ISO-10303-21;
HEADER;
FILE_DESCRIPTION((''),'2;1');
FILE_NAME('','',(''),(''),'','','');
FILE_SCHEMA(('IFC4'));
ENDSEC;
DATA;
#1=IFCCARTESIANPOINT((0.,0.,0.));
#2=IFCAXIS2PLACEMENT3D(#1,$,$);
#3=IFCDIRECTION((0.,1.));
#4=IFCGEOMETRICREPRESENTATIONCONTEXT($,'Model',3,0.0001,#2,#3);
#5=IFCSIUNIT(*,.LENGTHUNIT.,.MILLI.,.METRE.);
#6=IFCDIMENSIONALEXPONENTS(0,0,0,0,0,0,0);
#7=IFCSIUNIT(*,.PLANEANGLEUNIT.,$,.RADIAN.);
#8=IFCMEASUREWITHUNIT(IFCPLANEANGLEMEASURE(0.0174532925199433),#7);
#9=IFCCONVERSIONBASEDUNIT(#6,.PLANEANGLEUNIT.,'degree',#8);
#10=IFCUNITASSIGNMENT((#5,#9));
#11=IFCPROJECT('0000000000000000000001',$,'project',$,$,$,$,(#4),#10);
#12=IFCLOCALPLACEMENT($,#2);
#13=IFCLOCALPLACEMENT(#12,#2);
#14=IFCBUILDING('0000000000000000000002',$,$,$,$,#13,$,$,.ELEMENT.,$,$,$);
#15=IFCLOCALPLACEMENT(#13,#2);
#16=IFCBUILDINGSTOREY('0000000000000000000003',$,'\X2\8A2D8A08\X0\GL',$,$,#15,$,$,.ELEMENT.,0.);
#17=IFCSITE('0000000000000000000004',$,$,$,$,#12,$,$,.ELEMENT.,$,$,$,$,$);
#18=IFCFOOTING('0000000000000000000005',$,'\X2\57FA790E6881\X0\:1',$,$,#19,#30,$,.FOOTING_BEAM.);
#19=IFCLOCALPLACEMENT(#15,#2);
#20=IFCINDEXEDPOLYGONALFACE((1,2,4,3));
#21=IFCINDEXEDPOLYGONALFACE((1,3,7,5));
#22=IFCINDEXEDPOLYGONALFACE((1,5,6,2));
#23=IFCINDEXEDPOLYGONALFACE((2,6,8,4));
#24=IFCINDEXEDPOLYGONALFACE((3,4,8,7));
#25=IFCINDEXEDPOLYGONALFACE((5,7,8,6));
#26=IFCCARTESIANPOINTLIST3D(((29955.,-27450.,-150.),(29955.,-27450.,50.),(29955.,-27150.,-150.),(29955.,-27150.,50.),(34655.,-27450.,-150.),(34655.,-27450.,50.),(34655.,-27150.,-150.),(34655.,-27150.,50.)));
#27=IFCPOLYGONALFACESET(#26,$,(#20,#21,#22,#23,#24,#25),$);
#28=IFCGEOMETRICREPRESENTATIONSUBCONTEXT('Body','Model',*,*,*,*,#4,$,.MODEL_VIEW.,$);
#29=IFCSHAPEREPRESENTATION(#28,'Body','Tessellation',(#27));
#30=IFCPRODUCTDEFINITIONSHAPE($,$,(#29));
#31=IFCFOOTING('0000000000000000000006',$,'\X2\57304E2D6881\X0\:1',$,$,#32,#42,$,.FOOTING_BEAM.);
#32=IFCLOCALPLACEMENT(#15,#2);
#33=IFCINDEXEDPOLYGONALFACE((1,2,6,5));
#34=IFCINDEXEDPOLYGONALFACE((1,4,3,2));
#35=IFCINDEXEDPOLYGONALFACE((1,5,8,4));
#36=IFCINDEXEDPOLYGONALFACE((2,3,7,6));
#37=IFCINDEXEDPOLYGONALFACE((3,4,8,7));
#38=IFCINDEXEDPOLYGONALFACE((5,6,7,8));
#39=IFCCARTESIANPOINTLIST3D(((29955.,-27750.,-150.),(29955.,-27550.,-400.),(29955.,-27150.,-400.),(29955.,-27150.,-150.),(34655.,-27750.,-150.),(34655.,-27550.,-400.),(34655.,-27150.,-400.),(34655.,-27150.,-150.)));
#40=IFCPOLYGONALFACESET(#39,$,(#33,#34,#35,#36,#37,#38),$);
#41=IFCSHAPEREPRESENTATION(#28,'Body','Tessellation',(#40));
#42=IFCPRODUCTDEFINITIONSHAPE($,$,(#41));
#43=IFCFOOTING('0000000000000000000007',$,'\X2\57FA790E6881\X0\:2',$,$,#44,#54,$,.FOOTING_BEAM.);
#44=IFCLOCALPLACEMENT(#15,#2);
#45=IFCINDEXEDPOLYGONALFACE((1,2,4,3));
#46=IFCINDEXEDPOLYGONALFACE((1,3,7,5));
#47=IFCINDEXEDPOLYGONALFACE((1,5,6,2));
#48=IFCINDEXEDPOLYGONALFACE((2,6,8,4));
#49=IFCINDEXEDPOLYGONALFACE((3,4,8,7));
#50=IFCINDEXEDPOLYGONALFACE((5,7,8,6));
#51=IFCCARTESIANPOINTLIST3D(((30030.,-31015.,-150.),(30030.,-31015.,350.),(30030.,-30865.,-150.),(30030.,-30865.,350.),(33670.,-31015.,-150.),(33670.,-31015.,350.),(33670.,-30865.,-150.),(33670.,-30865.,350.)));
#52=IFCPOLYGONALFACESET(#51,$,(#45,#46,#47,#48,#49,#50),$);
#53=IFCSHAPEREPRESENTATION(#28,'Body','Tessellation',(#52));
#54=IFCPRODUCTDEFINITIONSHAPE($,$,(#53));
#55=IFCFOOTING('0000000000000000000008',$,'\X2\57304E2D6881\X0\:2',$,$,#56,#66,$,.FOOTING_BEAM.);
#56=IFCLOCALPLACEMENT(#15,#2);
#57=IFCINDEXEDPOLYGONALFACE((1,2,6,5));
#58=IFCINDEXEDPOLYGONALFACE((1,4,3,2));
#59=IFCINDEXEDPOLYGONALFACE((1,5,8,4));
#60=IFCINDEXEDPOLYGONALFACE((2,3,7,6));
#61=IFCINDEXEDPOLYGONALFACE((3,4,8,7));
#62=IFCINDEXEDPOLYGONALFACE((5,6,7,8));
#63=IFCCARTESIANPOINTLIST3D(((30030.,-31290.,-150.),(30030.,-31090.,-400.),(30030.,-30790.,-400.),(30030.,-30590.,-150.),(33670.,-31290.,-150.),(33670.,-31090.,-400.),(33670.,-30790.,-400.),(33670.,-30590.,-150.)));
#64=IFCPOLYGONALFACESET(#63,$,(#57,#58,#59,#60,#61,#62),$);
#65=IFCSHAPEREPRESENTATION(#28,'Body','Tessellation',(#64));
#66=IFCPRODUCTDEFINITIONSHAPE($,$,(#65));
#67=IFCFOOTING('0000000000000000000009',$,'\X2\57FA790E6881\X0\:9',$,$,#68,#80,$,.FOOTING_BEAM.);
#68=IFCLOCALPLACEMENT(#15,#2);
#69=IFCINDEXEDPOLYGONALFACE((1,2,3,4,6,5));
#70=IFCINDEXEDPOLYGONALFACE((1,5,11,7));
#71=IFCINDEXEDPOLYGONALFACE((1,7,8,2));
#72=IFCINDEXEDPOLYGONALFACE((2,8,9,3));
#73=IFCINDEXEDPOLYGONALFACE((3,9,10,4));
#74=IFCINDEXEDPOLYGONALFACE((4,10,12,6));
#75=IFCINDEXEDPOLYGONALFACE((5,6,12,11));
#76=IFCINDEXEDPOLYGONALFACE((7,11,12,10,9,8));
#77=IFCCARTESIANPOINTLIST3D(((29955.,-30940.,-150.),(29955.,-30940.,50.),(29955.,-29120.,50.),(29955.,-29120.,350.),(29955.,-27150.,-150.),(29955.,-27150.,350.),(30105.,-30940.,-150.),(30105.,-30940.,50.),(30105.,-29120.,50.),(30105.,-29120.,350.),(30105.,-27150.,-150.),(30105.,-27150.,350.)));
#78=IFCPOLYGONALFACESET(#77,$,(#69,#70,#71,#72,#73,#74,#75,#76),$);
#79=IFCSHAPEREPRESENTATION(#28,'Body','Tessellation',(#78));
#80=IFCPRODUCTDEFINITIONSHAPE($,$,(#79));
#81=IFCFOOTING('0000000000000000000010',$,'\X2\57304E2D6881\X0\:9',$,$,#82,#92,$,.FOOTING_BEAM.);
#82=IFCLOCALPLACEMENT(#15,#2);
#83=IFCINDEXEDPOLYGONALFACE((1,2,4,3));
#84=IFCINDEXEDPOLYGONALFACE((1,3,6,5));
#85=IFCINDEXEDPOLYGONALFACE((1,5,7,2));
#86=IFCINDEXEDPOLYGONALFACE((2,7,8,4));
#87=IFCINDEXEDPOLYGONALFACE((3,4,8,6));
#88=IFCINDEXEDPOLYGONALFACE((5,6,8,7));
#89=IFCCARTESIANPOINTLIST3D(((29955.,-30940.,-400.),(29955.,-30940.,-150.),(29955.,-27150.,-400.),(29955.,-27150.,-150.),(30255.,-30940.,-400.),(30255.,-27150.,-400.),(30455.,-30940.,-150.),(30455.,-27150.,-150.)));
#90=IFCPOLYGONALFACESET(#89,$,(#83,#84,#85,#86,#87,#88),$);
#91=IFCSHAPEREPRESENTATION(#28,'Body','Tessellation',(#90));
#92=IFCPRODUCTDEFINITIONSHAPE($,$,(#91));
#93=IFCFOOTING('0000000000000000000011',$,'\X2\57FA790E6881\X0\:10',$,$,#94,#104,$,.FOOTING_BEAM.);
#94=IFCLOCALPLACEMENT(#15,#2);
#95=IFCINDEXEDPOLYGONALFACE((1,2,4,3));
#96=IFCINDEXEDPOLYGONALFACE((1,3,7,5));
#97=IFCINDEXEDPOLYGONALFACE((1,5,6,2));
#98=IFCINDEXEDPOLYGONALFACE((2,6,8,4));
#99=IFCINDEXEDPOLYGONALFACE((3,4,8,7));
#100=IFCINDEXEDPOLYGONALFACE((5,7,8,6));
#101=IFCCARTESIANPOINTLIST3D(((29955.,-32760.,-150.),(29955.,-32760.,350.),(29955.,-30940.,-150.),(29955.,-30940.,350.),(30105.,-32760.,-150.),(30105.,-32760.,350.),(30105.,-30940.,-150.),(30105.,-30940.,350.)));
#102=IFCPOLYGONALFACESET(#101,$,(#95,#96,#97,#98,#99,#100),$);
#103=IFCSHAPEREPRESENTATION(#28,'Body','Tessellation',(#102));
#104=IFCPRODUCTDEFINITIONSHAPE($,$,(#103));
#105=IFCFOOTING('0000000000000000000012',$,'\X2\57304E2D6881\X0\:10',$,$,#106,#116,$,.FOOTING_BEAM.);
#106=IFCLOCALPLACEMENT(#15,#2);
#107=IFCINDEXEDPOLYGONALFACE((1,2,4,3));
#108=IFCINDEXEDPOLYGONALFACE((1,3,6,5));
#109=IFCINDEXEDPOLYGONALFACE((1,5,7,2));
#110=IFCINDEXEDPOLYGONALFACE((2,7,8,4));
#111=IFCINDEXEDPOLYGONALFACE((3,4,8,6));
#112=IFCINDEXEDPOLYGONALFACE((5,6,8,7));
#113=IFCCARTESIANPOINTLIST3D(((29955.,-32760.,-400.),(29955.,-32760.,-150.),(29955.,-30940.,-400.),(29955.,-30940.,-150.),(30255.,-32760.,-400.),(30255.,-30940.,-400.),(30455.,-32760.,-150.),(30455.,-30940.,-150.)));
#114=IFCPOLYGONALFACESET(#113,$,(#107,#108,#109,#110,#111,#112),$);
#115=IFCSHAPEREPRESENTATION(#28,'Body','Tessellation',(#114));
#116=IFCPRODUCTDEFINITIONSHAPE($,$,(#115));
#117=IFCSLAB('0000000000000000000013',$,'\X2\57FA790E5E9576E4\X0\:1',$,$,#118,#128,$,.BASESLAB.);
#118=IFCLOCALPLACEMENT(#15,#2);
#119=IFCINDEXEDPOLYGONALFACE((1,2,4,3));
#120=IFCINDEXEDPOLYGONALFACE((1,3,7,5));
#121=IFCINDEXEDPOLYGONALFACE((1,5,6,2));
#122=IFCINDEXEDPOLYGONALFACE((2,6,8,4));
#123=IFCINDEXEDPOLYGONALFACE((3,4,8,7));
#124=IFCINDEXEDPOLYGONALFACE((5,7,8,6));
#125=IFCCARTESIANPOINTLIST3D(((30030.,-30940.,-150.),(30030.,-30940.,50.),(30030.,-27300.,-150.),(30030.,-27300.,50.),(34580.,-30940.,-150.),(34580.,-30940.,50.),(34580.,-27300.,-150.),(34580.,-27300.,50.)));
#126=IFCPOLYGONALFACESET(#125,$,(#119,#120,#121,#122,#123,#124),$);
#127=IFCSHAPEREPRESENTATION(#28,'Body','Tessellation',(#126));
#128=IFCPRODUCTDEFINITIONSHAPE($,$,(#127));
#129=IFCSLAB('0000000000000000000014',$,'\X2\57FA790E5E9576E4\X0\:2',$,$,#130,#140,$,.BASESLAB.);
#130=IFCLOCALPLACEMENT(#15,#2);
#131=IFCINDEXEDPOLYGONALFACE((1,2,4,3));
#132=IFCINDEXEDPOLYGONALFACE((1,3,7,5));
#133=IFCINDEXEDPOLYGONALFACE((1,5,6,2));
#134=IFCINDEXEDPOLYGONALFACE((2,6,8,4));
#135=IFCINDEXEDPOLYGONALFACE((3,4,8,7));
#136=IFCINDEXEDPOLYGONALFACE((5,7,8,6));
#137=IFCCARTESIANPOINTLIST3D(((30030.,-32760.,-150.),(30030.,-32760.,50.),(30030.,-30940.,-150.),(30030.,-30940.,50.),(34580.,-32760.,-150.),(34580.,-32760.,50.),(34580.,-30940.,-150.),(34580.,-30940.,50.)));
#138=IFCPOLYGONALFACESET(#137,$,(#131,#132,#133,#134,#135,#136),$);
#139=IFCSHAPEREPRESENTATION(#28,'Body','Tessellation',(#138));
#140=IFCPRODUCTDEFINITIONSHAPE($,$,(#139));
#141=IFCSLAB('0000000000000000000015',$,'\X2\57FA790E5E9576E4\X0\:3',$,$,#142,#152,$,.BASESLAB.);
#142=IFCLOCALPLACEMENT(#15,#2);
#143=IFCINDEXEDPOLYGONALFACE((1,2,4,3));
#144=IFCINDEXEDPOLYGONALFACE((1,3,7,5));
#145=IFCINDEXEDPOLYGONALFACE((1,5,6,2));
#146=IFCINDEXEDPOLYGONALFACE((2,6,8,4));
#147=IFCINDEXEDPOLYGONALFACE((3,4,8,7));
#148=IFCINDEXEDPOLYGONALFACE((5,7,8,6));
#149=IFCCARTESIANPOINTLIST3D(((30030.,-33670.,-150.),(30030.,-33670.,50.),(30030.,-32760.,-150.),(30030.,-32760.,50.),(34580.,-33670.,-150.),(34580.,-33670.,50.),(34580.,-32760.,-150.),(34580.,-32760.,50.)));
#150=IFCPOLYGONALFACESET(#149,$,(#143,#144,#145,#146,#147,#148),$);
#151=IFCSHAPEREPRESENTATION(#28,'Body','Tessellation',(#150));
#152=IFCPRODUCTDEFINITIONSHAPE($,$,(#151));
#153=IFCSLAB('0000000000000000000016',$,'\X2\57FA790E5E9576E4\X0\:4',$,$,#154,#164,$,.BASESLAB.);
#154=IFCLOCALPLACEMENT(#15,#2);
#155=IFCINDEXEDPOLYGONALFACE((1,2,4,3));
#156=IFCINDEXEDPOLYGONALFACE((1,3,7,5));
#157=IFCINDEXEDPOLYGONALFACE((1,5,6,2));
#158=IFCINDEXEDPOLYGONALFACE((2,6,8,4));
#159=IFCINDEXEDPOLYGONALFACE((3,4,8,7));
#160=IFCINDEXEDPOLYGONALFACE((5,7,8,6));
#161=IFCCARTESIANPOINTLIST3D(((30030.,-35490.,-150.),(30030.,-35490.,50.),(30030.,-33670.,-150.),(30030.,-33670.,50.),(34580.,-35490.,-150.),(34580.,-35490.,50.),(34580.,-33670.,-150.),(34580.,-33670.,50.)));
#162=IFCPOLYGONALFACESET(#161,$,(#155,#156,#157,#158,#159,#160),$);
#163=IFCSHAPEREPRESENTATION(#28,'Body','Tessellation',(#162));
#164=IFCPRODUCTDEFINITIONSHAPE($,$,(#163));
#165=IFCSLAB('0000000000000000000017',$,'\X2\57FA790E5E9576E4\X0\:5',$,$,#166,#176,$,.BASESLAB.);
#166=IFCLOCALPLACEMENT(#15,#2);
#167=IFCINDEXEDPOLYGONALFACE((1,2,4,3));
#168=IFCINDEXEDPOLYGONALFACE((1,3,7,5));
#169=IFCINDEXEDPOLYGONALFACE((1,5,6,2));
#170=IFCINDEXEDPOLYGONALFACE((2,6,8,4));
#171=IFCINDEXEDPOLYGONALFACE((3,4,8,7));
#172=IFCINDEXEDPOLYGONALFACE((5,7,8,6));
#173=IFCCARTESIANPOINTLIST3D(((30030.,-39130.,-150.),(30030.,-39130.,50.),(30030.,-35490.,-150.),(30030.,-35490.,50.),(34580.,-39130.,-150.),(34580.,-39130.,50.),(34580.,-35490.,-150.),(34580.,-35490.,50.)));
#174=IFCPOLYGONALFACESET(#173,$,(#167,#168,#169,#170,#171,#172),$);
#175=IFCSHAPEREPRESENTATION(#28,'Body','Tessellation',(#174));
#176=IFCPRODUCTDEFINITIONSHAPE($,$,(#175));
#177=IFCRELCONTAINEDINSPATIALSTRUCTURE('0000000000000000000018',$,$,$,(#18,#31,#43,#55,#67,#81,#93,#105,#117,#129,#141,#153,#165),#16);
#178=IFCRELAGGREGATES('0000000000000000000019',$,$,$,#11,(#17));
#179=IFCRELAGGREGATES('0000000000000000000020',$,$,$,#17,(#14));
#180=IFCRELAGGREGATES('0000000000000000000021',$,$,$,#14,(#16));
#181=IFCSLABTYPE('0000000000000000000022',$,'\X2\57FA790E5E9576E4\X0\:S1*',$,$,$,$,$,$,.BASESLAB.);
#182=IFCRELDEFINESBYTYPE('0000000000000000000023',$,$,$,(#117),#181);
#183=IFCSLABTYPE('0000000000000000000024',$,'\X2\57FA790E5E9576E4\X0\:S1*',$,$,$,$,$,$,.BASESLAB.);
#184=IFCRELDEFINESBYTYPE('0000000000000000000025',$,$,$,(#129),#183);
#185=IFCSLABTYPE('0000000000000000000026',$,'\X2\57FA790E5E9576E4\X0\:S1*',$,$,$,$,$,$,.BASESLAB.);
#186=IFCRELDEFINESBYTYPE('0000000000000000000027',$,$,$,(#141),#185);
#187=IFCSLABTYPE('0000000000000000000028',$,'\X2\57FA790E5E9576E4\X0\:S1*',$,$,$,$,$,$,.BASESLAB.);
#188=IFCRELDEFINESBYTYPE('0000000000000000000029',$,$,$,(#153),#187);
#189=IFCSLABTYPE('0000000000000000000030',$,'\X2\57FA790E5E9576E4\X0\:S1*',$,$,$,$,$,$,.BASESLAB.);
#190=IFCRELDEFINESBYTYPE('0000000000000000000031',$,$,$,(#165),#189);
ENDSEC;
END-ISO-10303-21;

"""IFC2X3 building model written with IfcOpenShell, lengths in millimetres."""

from ifc_helpers import new_model, entity, si_unit, converted_unit, direction, frame, origin, origin_with_axes, origin_2d, place, context, subcontext, project, spatial, polyline, rectangle, outline, extrude, boolean, type_object, element, save


model = new_model("IFC2X3")

# Units and contexts
model_context = context("Model", 3, precision=0.0001, world=origin(), true_north=direction((0.0, 1.0)))
body_context = subcontext(model_context, "Body", "Model", "MODEL_VIEW")
ifc_project = project(units=[si_unit("LENGTHUNIT", "METRE", prefix="MILLI"), converted_unit("PLANEANGLEUNIT", "degree", entity("IfcPlaneAngleMeasure", 0.0174532925199433), si_unit("PLANEANGLEUNIT", "RADIAN"), dimensions=[0, 0, 0, 0, 0, 0, 0])], contexts=[model_context])

# Site, building, storey
site_placement = place(None, origin())
site = spatial("IfcSite", under=ifc_project, at=site_placement, CompositionType="ELEMENT")
building_placement = place(site_placement, origin())
building = spatial("IfcBuilding", under=site, at=building_placement, CompositionType="ELEMENT")
storey_placement = place(building_placement, origin())
storey = spatial("IfcBuildingStorey", under=building, at=storey_placement, Name="設計GL", CompositionType="ELEMENT", Elevation=0.0)

# Footings
footing_1_placement = place(storey_placement, frame((29955.0, -27300.0, -50.0), z_axis=(1.0, 0.0, 0.0), x_axis=(0.0, 1.0, 0.0)))
element("IfcFooting", 1, at=footing_1_placement, inside=storey, Name="基礎梁:1", PredefinedType="FOOTING_BEAM", context=body_context, shape_type="SolidModel", body=[
    extrude(rectangle(XDim=300.0, YDim=200.0, at=origin_2d()), origin_with_axes(), (0.0, 0.0, 1.0), 4700.0),
])
footing_2_placement = place(storey_placement, frame((29955.0, -27150.0, -400.0), z_axis=(1.0, 0.0, 0.0), x_axis=(0.0, 1.0, 0.0)))
element("IfcFooting", 2, at=footing_2_placement, inside=storey, Name="地中梁:1", PredefinedType="FOOTING_BEAM", context=body_context, shape_type="SweptSolid", body=[
    extrude(outline(polyline([(0.0, 0.0, 0.0), (-400.0, 0.0, 0.0), (-600.0, 250.0, 0.0), (0.0, 250.0, 0.0), (0.0, 0.0, 0.0)])), origin_with_axes(), (0.0, 0.0, 1.0), 4700.0),
])
footing_3_placement = place(storey_placement, frame((30030.0, -30940.0, 100.0), z_axis=(1.0, 0.0, 0.0), x_axis=(0.0, 1.0, 0.0)))
element("IfcFooting", 3, at=footing_3_placement, inside=storey, Name="基礎梁:2", PredefinedType="FOOTING_BEAM", context=body_context, shape_type="SolidModel", body=[
    extrude(rectangle(XDim=150.0, YDim=500.0, at=origin_2d()), origin_with_axes(), (0.0, 0.0, 1.0), 3640.0),
])
footing_4_placement = place(storey_placement, frame((30030.0, -30940.0, -400.0), z_axis=(1.0, 0.0, 0.0), x_axis=(0.0, 1.0, 0.0)))
element("IfcFooting", 4, at=footing_4_placement, inside=storey, Name="地中梁:2", PredefinedType="FOOTING_BEAM", context=body_context, shape_type="SweptSolid", body=[
    extrude(outline(polyline([(-150.0, 0.0, 0.0), (150.0, 0.0, 0.0), (350.0, 250.0, 0.0), (-350.0, 250.0, 0.0), (-150.0, 0.0, 0.0)])), origin_with_axes(), (0.0, 0.0, 1.0), 3640.0),
])
footing_5_placement = place(storey_placement, frame((30030.0, -27150.0, 100.0), z_axis=(0.0, -1.0, 0.0), x_axis=(1.0, 0.0, 0.0)))
element("IfcFooting", 5, at=footing_5_placement, inside=storey, Name="基礎梁:9", PredefinedType="FOOTING_BEAM", context=body_context, shape_type="CSG", body=[
    boolean("DIFFERENCE", extrude(rectangle(XDim=150.0, YDim=500.0, at=origin_2d()), origin_with_axes(), (0.0, 0.0, 1.0), 3790.0), extrude(rectangle(XDim=154.0, YDim=300.0, at=origin_2d()), frame((0.0, 100.0, 1970.0), z_axis=(0.0, 0.0, 1.0), x_axis=(1.0, 0.0, 0.0)), (0.0, 0.0, 1.0), 1820.0)),
])
footing_6_placement = place(storey_placement, frame((29955.0, -27150.0, -400.0), z_axis=(0.0, -1.0, 0.0), x_axis=(1.0, 0.0, 0.0)))
element("IfcFooting", 6, at=footing_6_placement, inside=storey, Name="地中梁:9", PredefinedType="FOOTING_BEAM", context=body_context, shape_type="SweptSolid", body=[
    extrude(outline(polyline([(0.0, 0.0, 0.0), (300.0, 0.0, 0.0), (500.0, 250.0, 0.0), (0.0, 250.0, 0.0), (0.0, 0.0, 0.0)])), origin_with_axes(), (0.0, 0.0, 1.0), 3790.0),
])
footing_7_placement = place(storey_placement, frame((30030.0, -30940.0, 100.0), z_axis=(0.0, -1.0, 0.0), x_axis=(1.0, 0.0, 0.0)))
element("IfcFooting", 7, at=footing_7_placement, inside=storey, Name="基礎梁:10", PredefinedType="FOOTING_BEAM", context=body_context, shape_type="SolidModel", body=[
    extrude(rectangle(XDim=150.0, YDim=500.0, at=origin_2d()), origin_with_axes(), (0.0, 0.0, 1.0), 1820.0),
])
footing_8_placement = place(storey_placement, frame((29955.0, -30940.0, -400.0), z_axis=(0.0, -1.0, 0.0), x_axis=(1.0, 0.0, 0.0)))
element("IfcFooting", 8, at=footing_8_placement, inside=storey, Name="地中梁:10", PredefinedType="FOOTING_BEAM", context=body_context, shape_type="SweptSolid", body=[
    extrude(outline(polyline([(0.0, 0.0, 0.0), (300.0, 0.0, 0.0), (500.0, 250.0, 0.0), (0.0, 250.0, 0.0), (0.0, 0.0, 0.0)])), origin_with_axes(), (0.0, 0.0, 1.0), 1820.0),
])

# Slabs
slab_type_1 = type_object("IfcSlabType", Name="基礎底盤:S1*", PredefinedType="BASESLAB")
slab_1_placement = place(storey_placement, origin_with_axes())
element("IfcSlab", 9, at=slab_1_placement, inside=storey, type_object=slab_type_1, Name="基礎底盤:1", PredefinedType="BASESLAB", context=body_context, shape_type="SweptSolid", body=[
    extrude(outline(polyline([(34580.0, -27300.0, 0.0), (34580.0, -30940.0, 0.0), (30030.0, -30940.0, 0.0), (30030.0, -27300.0, 0.0), (34580.0, -27300.0, 0.0)])), frame((0.0, 0.0, -150.0), z_axis=(0.0, 0.0, 1.0), x_axis=(1.0, 0.0, 0.0)), (0.0, 0.0, 1.0), 200.0),
])
slab_type_2 = type_object("IfcSlabType", Name="基礎底盤:S1*", PredefinedType="BASESLAB")
slab_2_placement = place(storey_placement, origin_with_axes())
element("IfcSlab", 10, at=slab_2_placement, inside=storey, type_object=slab_type_2, Name="基礎底盤:2", PredefinedType="BASESLAB", context=body_context, shape_type="SweptSolid", body=[
    extrude(outline(polyline([(30030.0, -30940.0, 0.0), (30030.0, -32760.0, 0.0), (34580.0, -32760.0, 0.0), (34580.0, -30940.0, 0.0), (30030.0, -30940.0, 0.0)])), frame((0.0, 0.0, -150.0), z_axis=(0.0, 0.0, 1.0), x_axis=(1.0, 0.0, 0.0)), (0.0, 0.0, 1.0), 200.0),
])
slab_type_3 = type_object("IfcSlabType", Name="基礎底盤:S1*", PredefinedType="BASESLAB")
slab_3_placement = place(storey_placement, origin_with_axes())
element("IfcSlab", 11, at=slab_3_placement, inside=storey, type_object=slab_type_3, Name="基礎底盤:3", PredefinedType="BASESLAB", context=body_context, shape_type="SweptSolid", body=[
    extrude(outline(polyline([(34580.0, -32760.0, 0.0), (34580.0, -33670.0, 0.0), (30030.0, -33670.0, 0.0), (30030.0, -32760.0, 0.0), (34580.0, -32760.0, 0.0)])), frame((0.0, 0.0, -150.0), z_axis=(0.0, 0.0, 1.0), x_axis=(1.0, 0.0, 0.0)), (0.0, 0.0, 1.0), 200.0),
])
slab_type_4 = type_object("IfcSlabType", Name="基礎底盤:S1*", PredefinedType="BASESLAB")
slab_4_placement = place(storey_placement, origin_with_axes())
element("IfcSlab", 12, at=slab_4_placement, inside=storey, type_object=slab_type_4, Name="基礎底盤:4", PredefinedType="BASESLAB", context=body_context, shape_type="SweptSolid", body=[
    extrude(outline(polyline([(34580.0, -33670.0, 0.0), (34580.0, -35490.0, 0.0), (30030.0, -35490.0, 0.0), (30030.0, -33670.0, 0.0), (34580.0, -33670.0, 0.0)])), frame((0.0, 0.0, -150.0), z_axis=(0.0, 0.0, 1.0), x_axis=(1.0, 0.0, 0.0)), (0.0, 0.0, 1.0), 200.0),
])
slab_type_5 = type_object("IfcSlabType", Name="基礎底盤:S1*", PredefinedType="BASESLAB")
slab_5_placement = place(storey_placement, origin_with_axes())
element("IfcSlab", 13, at=slab_5_placement, inside=storey, type_object=slab_type_5, Name="基礎底盤:5", PredefinedType="BASESLAB", context=body_context, shape_type="SweptSolid", body=[
    extrude(outline(polyline([(34580.0, -39130.0, 0.0), (30030.0, -39130.0, 0.0), (30030.0, -35490.0, 0.0), (34580.0, -35490.0, 0.0), (34580.0, -39130.0, 0.0)])), frame((0.0, 0.0, -150.0), z_axis=(0.0, 0.0, 1.0), x_axis=(1.0, 0.0, 0.0)), (0.0, 0.0, 1.0), 200.0),
])

save(model, "model.ifc")
